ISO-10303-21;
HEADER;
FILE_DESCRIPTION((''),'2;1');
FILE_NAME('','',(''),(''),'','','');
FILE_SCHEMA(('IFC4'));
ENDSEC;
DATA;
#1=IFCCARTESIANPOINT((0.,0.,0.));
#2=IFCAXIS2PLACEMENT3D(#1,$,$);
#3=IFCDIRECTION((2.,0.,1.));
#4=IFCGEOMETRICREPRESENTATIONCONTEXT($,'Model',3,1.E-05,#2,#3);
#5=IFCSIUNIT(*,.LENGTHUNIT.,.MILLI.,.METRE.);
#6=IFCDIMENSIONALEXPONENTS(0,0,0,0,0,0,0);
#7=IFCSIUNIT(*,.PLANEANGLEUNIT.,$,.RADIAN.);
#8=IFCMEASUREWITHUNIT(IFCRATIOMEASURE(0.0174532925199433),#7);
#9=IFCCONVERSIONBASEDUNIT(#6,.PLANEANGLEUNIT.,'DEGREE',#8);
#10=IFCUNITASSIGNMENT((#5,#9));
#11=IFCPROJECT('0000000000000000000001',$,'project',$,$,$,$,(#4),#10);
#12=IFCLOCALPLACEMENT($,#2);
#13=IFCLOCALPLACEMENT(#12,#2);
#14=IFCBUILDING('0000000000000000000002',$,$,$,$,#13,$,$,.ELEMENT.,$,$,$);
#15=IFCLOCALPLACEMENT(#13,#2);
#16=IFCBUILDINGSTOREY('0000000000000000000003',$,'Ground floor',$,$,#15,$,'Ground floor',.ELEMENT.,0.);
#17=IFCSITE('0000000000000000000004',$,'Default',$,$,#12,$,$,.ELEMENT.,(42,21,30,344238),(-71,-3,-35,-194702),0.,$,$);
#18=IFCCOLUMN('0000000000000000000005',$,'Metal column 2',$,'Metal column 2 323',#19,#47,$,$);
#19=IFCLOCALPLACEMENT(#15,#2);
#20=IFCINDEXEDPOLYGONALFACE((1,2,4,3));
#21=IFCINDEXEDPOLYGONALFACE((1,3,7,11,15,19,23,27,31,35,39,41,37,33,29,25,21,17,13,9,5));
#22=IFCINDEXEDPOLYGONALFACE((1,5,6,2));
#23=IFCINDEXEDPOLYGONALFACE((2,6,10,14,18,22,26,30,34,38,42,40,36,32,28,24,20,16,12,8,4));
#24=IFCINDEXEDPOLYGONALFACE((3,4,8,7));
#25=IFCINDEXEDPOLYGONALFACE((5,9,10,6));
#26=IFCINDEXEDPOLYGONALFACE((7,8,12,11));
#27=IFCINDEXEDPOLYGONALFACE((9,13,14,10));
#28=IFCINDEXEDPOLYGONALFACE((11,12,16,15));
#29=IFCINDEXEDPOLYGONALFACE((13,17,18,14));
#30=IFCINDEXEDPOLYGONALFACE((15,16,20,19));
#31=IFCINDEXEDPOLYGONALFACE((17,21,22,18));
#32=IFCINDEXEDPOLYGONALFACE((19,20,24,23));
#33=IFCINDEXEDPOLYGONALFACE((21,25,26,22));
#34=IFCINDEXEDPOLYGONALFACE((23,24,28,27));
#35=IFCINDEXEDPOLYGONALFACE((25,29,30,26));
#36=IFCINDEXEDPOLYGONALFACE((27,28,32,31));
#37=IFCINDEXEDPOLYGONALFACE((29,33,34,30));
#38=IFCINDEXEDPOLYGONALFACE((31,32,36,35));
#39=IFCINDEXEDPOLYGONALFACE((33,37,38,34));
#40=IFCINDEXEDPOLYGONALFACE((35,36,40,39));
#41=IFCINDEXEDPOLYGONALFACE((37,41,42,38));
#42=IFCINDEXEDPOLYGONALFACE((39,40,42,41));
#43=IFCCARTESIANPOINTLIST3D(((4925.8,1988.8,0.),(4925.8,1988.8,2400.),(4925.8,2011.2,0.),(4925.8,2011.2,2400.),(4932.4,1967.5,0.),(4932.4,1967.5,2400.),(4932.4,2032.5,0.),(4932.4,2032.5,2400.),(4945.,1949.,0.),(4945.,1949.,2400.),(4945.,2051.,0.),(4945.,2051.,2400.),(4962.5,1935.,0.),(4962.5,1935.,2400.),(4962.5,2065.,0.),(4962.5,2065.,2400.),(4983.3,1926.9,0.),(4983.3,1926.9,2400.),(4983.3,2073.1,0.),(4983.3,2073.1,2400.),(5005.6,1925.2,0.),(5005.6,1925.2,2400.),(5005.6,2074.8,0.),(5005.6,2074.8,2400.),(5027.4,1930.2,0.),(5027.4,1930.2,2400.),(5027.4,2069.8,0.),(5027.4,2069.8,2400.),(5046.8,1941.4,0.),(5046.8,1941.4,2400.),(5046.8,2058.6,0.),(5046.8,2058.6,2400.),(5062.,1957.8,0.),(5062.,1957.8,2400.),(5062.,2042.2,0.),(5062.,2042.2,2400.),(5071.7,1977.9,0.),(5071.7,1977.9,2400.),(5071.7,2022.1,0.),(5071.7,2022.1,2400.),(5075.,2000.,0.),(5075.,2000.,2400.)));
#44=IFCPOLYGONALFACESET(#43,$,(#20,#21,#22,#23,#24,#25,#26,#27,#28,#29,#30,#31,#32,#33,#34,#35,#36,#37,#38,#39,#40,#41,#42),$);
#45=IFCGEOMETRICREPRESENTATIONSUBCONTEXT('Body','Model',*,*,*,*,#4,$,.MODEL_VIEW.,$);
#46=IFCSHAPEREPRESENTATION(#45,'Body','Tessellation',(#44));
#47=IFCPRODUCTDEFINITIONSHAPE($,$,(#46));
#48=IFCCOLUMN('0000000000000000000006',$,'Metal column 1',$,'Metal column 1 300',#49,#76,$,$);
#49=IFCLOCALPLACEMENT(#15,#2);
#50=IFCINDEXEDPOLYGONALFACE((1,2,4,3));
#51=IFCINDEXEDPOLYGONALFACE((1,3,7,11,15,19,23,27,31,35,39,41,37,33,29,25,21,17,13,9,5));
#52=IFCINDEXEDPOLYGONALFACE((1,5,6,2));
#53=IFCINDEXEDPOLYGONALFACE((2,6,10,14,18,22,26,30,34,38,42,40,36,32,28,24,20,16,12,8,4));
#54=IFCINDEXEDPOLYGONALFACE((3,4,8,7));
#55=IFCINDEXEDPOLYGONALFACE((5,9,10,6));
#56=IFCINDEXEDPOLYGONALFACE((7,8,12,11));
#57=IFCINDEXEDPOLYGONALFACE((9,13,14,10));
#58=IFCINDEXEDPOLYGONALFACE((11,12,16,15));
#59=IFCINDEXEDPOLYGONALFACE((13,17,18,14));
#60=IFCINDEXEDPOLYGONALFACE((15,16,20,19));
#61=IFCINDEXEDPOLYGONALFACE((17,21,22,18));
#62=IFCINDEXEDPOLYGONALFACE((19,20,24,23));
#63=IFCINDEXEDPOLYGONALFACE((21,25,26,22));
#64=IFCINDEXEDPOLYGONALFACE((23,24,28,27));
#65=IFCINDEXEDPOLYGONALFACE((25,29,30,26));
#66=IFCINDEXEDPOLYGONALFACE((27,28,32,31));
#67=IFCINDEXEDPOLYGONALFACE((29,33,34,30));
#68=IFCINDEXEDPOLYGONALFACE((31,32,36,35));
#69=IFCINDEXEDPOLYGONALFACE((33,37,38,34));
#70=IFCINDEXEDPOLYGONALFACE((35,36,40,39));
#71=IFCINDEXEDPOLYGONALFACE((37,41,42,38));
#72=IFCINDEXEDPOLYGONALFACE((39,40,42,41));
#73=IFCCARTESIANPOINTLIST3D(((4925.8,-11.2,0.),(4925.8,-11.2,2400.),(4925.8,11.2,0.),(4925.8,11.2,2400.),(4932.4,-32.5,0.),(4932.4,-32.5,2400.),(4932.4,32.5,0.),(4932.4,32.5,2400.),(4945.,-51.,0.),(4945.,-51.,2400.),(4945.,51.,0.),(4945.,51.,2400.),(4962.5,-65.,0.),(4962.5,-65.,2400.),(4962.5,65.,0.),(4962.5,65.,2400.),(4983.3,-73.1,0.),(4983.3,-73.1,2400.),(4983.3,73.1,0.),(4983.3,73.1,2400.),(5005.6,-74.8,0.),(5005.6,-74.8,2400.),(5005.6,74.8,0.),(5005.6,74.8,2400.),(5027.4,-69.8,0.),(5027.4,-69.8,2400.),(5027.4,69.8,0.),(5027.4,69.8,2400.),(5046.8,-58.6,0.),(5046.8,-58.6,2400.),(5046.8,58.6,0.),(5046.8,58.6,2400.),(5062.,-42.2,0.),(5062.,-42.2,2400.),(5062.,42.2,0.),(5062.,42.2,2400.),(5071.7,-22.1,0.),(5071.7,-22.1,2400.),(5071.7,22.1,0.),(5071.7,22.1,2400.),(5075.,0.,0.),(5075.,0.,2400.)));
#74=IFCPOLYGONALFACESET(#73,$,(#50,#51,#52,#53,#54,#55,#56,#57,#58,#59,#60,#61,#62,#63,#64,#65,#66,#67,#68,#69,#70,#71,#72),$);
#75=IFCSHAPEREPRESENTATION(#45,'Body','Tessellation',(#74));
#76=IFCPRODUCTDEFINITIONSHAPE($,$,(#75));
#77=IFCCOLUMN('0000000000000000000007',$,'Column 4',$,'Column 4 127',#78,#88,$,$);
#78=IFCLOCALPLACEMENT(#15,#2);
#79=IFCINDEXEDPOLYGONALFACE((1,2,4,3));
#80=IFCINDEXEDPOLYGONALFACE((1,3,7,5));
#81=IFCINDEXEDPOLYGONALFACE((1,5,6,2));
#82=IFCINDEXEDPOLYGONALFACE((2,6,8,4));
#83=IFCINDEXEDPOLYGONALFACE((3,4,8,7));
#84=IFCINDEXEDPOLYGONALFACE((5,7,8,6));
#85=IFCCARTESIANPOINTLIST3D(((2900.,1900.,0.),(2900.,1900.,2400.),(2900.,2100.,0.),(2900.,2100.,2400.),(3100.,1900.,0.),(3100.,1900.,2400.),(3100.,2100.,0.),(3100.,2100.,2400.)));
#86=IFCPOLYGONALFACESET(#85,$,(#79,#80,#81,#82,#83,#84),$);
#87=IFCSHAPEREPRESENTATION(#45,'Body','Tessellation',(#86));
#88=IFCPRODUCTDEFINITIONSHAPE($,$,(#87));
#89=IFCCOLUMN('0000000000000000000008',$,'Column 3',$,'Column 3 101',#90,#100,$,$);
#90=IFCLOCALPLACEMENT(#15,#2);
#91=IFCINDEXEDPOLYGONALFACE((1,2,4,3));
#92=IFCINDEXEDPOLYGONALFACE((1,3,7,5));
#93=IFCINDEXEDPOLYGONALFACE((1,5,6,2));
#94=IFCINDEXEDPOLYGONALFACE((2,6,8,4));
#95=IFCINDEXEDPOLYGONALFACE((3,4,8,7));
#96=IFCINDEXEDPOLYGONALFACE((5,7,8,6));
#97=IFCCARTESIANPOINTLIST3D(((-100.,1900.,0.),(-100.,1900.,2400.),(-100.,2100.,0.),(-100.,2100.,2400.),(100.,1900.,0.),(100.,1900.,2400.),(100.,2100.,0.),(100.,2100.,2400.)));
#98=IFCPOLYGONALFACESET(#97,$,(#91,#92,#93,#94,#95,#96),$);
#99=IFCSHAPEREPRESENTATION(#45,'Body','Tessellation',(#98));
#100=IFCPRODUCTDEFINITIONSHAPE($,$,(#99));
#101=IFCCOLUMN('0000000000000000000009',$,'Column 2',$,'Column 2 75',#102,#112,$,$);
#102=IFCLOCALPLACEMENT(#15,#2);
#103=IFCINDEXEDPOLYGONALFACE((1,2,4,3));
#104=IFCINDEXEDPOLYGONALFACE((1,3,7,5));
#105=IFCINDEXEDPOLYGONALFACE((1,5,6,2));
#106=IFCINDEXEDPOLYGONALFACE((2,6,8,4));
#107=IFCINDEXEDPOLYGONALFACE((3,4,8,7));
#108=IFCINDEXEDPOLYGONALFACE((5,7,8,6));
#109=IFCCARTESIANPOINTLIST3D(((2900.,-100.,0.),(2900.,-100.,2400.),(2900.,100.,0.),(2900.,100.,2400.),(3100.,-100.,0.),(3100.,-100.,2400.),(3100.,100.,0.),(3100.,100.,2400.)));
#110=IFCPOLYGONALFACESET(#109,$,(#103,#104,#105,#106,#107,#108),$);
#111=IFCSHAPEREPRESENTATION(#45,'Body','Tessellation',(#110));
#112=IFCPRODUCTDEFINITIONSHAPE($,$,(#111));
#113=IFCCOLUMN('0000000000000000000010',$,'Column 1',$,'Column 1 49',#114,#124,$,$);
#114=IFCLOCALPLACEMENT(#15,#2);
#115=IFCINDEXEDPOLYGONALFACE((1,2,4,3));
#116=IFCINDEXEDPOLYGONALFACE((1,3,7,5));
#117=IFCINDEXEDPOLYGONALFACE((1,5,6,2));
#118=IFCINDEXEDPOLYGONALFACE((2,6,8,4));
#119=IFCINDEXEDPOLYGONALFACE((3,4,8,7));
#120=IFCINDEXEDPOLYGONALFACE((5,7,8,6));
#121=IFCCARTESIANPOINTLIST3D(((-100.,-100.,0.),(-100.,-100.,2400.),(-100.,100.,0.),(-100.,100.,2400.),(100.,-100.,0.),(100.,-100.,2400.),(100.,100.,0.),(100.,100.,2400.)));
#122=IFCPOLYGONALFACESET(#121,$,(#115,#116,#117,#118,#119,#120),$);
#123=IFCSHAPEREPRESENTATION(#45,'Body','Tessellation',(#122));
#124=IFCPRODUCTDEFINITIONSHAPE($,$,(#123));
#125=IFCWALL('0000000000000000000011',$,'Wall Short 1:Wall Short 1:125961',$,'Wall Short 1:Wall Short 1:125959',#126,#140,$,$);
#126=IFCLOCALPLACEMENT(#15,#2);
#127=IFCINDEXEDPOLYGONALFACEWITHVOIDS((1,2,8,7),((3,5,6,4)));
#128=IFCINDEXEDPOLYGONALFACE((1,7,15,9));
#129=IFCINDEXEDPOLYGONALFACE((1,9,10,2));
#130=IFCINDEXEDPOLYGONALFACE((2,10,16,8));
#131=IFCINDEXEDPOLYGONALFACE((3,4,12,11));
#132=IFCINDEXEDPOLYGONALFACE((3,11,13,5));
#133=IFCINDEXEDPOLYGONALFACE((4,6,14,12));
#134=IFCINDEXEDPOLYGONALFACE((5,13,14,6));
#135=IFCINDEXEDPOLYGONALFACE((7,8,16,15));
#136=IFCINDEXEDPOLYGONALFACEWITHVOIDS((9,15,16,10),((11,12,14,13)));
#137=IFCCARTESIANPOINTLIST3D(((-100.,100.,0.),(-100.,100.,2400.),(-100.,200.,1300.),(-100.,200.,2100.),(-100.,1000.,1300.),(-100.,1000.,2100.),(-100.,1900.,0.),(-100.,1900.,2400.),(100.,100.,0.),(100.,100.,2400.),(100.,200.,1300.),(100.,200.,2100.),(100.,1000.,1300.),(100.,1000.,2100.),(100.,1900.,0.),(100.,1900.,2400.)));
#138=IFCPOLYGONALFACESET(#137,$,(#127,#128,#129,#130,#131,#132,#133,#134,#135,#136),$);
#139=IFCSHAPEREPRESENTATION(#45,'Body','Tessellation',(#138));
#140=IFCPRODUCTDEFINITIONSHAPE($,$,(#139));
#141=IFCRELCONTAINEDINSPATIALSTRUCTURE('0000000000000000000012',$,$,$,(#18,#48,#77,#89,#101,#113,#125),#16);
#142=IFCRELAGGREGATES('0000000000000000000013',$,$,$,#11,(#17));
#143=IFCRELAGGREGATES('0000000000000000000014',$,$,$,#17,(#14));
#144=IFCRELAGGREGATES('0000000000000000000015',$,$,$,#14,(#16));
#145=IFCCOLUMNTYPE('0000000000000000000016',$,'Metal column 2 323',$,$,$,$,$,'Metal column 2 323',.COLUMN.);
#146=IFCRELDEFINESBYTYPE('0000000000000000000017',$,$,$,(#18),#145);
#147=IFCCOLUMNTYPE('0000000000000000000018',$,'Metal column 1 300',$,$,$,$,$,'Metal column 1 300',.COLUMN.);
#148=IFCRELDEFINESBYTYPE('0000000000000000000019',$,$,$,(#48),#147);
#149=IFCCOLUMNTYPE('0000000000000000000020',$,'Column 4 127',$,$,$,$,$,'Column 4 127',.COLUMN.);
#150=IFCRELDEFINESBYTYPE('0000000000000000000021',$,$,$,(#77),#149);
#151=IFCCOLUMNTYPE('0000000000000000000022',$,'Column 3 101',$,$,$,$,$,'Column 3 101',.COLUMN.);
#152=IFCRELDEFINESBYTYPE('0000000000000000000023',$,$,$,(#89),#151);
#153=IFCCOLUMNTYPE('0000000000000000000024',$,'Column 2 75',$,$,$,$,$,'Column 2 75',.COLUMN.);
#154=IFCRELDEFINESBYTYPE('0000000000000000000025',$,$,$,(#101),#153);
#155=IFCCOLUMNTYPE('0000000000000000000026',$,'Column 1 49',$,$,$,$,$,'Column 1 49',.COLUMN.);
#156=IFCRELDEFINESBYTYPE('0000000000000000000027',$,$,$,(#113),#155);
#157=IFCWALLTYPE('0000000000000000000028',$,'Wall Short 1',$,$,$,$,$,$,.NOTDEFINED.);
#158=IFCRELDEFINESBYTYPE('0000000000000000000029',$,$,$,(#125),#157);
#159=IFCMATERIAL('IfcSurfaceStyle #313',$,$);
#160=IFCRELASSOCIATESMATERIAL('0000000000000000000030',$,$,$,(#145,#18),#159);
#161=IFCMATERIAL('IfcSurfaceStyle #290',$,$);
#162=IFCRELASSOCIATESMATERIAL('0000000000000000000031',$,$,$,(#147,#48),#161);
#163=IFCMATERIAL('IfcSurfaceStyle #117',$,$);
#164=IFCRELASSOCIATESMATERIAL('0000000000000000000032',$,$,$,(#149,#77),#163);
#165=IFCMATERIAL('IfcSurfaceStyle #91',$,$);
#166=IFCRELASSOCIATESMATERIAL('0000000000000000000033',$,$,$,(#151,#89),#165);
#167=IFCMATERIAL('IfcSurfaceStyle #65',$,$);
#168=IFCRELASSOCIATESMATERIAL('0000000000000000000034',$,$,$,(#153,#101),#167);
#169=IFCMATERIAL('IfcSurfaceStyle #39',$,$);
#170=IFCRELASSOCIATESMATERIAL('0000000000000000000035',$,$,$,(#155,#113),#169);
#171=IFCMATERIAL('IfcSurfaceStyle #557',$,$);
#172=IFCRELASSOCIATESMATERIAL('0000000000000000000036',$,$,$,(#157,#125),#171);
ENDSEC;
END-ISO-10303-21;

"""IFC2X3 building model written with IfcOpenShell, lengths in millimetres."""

from ifc_helpers import new_model, entity, si_unit, converted_unit, direction, frame, frame_2d, origin, origin_2d_with_axis, place, context, subcontext, project, spatial, rectangle, circle, extrude, source, transform, mapped, material, type_object, type_shapes, element, save


model = new_model("IFC2X3")

# Units and contexts
model_context = context("Model", 3, precision=1e-05, world=origin(), true_north=direction((2.0, 0.0, 1.0)))
body_context = subcontext(model_context, "Body", "Model", "MODEL_VIEW")
ifc_project = project(units=[si_unit("LENGTHUNIT", "METRE", prefix="MILLI"), converted_unit("PLANEANGLEUNIT", "DEGREE", entity("IfcRatioMeasure", 0.0174532925199433), si_unit("PLANEANGLEUNIT", "RADIAN"), dimensions=[0, 0, 0, 0, 0, 0, 0])], contexts=[model_context])

# Site, building, storey
site_placement = place(None, origin())
site = spatial("IfcSite", under=ifc_project, at=site_placement, Name="Default", CompositionType="ELEMENT", RefLatitude=(42, 21, 30, 344238), RefLongitude=(-71, -3, -35, -194702), RefElevation=0.0)
building_placement = place(site_placement, origin())
building = spatial("IfcBuilding", under=site, at=building_placement, CompositionType="ELEMENT")
storey_placement = place(building_placement, origin())
storey = spatial("IfcBuildingStorey", under=building, at=storey_placement, Name="Ground floor", LongName="Ground floor", CompositionType="ELEMENT", Elevation=0.0)

# Columns
ifc_material_1 = material(Name="IfcSurfaceStyle #313")
column_type_1 = type_object("IfcColumnType", Name="Metal column 2 323", ElementType="Metal column 2 323", PredefinedType="COLUMN", material=ifc_material_1)
shared_shape_1 = source(origin(), body_context, "Body", "SweptSolid", [
    extrude(circle(Radius=75.0, at=frame_2d((0.0, 0.0), x_axis=(1.0, 0.0))), frame((5000.0, 2000.0, 0.0)), (0.0, 0.0, 1.0), 2400.0),
])
type_shapes(column_type_1, [shared_shape_1])
column_1_placement = place(building_placement, origin())
element("IfcColumn", 1, at=column_1_placement, inside=storey, type_object=column_type_1, material=ifc_material_1, Name="Metal column 2", ObjectType="Metal column 2 323", context=body_context, shape_type="MappedRepresentation", body=[
    mapped(shared_shape_1, transform((0.0, 0.0, 0.0), scale=1.0)),
])
ifc_material_2 = material(Name="IfcSurfaceStyle #290")
column_type_2 = type_object("IfcColumnType", Name="Metal column 1 300", ElementType="Metal column 1 300", PredefinedType="COLUMN", material=ifc_material_2)
shared_shape_2 = source(origin(), body_context, "Body", "SweptSolid", [
    extrude(circle(Radius=75.0, at=frame_2d((0.0, 0.0), x_axis=(1.0, 0.0))), frame((5000.0, 0.0, 0.0)), (0.0, 0.0, 1.0), 2400.0),
])
type_shapes(column_type_2, [shared_shape_2])
column_2_placement = place(building_placement, origin())
element("IfcColumn", 2, at=column_2_placement, inside=storey, type_object=column_type_2, material=ifc_material_2, Name="Metal column 1", ObjectType="Metal column 1 300", context=body_context, shape_type="MappedRepresentation", body=[
    mapped(shared_shape_2, transform((0.0, 0.0, 0.0), scale=1.0)),
])
ifc_material_3 = material(Name="IfcSurfaceStyle #117")
column_type_3 = type_object("IfcColumnType", Name="Column 4 127", ElementType="Column 4 127", PredefinedType="COLUMN", material=ifc_material_3)
shared_shape_3 = source(origin(), body_context, "Body", "SweptSolid", [
    extrude(rectangle(XDim=200.0, YDim=200.0, at=origin_2d_with_axis()), frame((3000.0, 2000.0, 0.0), z_axis=(0.0, 0.0, 1.0), x_axis=(0.0, -1.0, 0.0)), (0.0, 0.0, 1.0), 2400.0),
])
type_shapes(column_type_3, [shared_shape_3])
column_3_placement = place(building_placement, origin())
element("IfcColumn", 3, at=column_3_placement, inside=storey, type_object=column_type_3, material=ifc_material_3, Name="Column 4", ObjectType="Column 4 127", context=body_context, shape_type="MappedRepresentation", body=[
    mapped(shared_shape_3, transform((0.0, 0.0, 0.0), scale=1.0)),
])
ifc_material_4 = material(Name="IfcSurfaceStyle #91")
column_type_4 = type_object("IfcColumnType", Name="Column 3 101", ElementType="Column 3 101", PredefinedType="COLUMN", material=ifc_material_4)
shared_shape_4 = source(origin(), body_context, "Body", "SweptSolid", [
    extrude(rectangle(XDim=200.0, YDim=200.0, at=origin_2d_with_axis()), frame((0.0, 2000.0, 0.0), z_axis=(0.0, 0.0, 1.0), x_axis=(0.0, -1.0, 0.0)), (0.0, 0.0, 1.0), 2400.0),
])
type_shapes(column_type_4, [shared_shape_4])
column_4_placement = place(building_placement, origin())
element("IfcColumn", 4, at=column_4_placement, inside=storey, type_object=column_type_4, material=ifc_material_4, Name="Column 3", ObjectType="Column 3 101", context=body_context, shape_type="MappedRepresentation", body=[
    mapped(shared_shape_4, transform((0.0, 0.0, 0.0), scale=1.0)),
])
ifc_material_5 = material(Name="IfcSurfaceStyle #65")
column_type_5 = type_object("IfcColumnType", Name="Column 2 75", ElementType="Column 2 75", PredefinedType="COLUMN", material=ifc_material_5)
shared_shape_5 = source(origin(), body_context, "Body", "SweptSolid", [
    extrude(rectangle(XDim=200.0, YDim=200.0, at=origin_2d_with_axis()), frame((3000.0, 0.0, 0.0), z_axis=(0.0, 0.0, 1.0), x_axis=(0.0, -1.0, 0.0)), (0.0, 0.0, 1.0), 2400.0),
])
type_shapes(column_type_5, [shared_shape_5])
column_5_placement = place(building_placement, origin())
element("IfcColumn", 5, at=column_5_placement, inside=storey, type_object=column_type_5, material=ifc_material_5, Name="Column 2", ObjectType="Column 2 75", context=body_context, shape_type="MappedRepresentation", body=[
    mapped(shared_shape_5, transform((0.0, 0.0, 0.0), scale=1.0)),
])
ifc_material_6 = material(Name="IfcSurfaceStyle #39")
column_type_6 = type_object("IfcColumnType", Name="Column 1 49", ElementType="Column 1 49", PredefinedType="COLUMN", material=ifc_material_6)
shared_shape_6 = source(origin(), body_context, "Body", "SweptSolid", [
    extrude(rectangle(XDim=200.0, YDim=200.0, at=origin_2d_with_axis()), frame((0.0, 0.0, 0.0), z_axis=(0.0, 0.0, 1.0), x_axis=(0.0, -1.0, 0.0)), (0.0, 0.0, 1.0), 2400.0),
])
type_shapes(column_type_6, [shared_shape_6])
column_6_placement = place(building_placement, origin())
element("IfcColumn", 6, at=column_6_placement, inside=storey, type_object=column_type_6, material=ifc_material_6, Name="Column 1", ObjectType="Column 1 49", context=body_context, shape_type="MappedRepresentation", body=[
    mapped(shared_shape_6, transform((0.0, 0.0, 0.0), scale=1.0)),
])

# Wall, opening
ifc_material_7 = material(Name="IfcSurfaceStyle #557")
wall_type_1 = type_object("IfcWallType", Name="Wall Short 1", PredefinedType="NOTDEFINED", material=ifc_material_7)
wall_1_placement = place(building_placement, frame((-100.0, 100.0, 0.0), z_axis=(0.0, 0.0, 1.0), x_axis=(0.0, 1.0, 0.0)))
wall_1 = element("IfcWall", 7, at=wall_1_placement, inside=storey, type_object=wall_type_1, material=ifc_material_7, Name="Wall Short 1:Wall Short 1:125961", ObjectType="Wall Short 1:Wall Short 1:125959", context=body_context, shape_type="SweptSolid", body=[
    extrude(rectangle(XDim=200.0, YDim=1800.0, at=origin_2d_with_axis()), frame((900.0, -100.0, 0.0), z_axis=(0.0, 0.0, 1.0), x_axis=(0.0, -1.0, 0.0)), (0.0, 0.0, 1.0), 2400.0),
])
opening_placement = place(building_placement, frame((-100.0, 100.0, 0.0), z_axis=(0.0, 0.0, 1.0), x_axis=(0.0, 1.0, 0.0)))
element("IfcOpeningElement", 8, at=opening_placement, cuts=wall_1, ObjectType="Opening", context=body_context, shape_type="SweptSolid", body=[
    extrude(rectangle(XDim=800.0, YDim=800.0, at=frame_2d((0.0, 0.0), x_axis=(0.0, 1.0))), frame((500.0, 0.0, 1700.0), z_axis=(0.0, -1.0, 0.0), x_axis=(-1.0, 0.0, 0.0)), (0.0, 0.0, 1.0), 200.0),
])

save(model, "model.ifc")
